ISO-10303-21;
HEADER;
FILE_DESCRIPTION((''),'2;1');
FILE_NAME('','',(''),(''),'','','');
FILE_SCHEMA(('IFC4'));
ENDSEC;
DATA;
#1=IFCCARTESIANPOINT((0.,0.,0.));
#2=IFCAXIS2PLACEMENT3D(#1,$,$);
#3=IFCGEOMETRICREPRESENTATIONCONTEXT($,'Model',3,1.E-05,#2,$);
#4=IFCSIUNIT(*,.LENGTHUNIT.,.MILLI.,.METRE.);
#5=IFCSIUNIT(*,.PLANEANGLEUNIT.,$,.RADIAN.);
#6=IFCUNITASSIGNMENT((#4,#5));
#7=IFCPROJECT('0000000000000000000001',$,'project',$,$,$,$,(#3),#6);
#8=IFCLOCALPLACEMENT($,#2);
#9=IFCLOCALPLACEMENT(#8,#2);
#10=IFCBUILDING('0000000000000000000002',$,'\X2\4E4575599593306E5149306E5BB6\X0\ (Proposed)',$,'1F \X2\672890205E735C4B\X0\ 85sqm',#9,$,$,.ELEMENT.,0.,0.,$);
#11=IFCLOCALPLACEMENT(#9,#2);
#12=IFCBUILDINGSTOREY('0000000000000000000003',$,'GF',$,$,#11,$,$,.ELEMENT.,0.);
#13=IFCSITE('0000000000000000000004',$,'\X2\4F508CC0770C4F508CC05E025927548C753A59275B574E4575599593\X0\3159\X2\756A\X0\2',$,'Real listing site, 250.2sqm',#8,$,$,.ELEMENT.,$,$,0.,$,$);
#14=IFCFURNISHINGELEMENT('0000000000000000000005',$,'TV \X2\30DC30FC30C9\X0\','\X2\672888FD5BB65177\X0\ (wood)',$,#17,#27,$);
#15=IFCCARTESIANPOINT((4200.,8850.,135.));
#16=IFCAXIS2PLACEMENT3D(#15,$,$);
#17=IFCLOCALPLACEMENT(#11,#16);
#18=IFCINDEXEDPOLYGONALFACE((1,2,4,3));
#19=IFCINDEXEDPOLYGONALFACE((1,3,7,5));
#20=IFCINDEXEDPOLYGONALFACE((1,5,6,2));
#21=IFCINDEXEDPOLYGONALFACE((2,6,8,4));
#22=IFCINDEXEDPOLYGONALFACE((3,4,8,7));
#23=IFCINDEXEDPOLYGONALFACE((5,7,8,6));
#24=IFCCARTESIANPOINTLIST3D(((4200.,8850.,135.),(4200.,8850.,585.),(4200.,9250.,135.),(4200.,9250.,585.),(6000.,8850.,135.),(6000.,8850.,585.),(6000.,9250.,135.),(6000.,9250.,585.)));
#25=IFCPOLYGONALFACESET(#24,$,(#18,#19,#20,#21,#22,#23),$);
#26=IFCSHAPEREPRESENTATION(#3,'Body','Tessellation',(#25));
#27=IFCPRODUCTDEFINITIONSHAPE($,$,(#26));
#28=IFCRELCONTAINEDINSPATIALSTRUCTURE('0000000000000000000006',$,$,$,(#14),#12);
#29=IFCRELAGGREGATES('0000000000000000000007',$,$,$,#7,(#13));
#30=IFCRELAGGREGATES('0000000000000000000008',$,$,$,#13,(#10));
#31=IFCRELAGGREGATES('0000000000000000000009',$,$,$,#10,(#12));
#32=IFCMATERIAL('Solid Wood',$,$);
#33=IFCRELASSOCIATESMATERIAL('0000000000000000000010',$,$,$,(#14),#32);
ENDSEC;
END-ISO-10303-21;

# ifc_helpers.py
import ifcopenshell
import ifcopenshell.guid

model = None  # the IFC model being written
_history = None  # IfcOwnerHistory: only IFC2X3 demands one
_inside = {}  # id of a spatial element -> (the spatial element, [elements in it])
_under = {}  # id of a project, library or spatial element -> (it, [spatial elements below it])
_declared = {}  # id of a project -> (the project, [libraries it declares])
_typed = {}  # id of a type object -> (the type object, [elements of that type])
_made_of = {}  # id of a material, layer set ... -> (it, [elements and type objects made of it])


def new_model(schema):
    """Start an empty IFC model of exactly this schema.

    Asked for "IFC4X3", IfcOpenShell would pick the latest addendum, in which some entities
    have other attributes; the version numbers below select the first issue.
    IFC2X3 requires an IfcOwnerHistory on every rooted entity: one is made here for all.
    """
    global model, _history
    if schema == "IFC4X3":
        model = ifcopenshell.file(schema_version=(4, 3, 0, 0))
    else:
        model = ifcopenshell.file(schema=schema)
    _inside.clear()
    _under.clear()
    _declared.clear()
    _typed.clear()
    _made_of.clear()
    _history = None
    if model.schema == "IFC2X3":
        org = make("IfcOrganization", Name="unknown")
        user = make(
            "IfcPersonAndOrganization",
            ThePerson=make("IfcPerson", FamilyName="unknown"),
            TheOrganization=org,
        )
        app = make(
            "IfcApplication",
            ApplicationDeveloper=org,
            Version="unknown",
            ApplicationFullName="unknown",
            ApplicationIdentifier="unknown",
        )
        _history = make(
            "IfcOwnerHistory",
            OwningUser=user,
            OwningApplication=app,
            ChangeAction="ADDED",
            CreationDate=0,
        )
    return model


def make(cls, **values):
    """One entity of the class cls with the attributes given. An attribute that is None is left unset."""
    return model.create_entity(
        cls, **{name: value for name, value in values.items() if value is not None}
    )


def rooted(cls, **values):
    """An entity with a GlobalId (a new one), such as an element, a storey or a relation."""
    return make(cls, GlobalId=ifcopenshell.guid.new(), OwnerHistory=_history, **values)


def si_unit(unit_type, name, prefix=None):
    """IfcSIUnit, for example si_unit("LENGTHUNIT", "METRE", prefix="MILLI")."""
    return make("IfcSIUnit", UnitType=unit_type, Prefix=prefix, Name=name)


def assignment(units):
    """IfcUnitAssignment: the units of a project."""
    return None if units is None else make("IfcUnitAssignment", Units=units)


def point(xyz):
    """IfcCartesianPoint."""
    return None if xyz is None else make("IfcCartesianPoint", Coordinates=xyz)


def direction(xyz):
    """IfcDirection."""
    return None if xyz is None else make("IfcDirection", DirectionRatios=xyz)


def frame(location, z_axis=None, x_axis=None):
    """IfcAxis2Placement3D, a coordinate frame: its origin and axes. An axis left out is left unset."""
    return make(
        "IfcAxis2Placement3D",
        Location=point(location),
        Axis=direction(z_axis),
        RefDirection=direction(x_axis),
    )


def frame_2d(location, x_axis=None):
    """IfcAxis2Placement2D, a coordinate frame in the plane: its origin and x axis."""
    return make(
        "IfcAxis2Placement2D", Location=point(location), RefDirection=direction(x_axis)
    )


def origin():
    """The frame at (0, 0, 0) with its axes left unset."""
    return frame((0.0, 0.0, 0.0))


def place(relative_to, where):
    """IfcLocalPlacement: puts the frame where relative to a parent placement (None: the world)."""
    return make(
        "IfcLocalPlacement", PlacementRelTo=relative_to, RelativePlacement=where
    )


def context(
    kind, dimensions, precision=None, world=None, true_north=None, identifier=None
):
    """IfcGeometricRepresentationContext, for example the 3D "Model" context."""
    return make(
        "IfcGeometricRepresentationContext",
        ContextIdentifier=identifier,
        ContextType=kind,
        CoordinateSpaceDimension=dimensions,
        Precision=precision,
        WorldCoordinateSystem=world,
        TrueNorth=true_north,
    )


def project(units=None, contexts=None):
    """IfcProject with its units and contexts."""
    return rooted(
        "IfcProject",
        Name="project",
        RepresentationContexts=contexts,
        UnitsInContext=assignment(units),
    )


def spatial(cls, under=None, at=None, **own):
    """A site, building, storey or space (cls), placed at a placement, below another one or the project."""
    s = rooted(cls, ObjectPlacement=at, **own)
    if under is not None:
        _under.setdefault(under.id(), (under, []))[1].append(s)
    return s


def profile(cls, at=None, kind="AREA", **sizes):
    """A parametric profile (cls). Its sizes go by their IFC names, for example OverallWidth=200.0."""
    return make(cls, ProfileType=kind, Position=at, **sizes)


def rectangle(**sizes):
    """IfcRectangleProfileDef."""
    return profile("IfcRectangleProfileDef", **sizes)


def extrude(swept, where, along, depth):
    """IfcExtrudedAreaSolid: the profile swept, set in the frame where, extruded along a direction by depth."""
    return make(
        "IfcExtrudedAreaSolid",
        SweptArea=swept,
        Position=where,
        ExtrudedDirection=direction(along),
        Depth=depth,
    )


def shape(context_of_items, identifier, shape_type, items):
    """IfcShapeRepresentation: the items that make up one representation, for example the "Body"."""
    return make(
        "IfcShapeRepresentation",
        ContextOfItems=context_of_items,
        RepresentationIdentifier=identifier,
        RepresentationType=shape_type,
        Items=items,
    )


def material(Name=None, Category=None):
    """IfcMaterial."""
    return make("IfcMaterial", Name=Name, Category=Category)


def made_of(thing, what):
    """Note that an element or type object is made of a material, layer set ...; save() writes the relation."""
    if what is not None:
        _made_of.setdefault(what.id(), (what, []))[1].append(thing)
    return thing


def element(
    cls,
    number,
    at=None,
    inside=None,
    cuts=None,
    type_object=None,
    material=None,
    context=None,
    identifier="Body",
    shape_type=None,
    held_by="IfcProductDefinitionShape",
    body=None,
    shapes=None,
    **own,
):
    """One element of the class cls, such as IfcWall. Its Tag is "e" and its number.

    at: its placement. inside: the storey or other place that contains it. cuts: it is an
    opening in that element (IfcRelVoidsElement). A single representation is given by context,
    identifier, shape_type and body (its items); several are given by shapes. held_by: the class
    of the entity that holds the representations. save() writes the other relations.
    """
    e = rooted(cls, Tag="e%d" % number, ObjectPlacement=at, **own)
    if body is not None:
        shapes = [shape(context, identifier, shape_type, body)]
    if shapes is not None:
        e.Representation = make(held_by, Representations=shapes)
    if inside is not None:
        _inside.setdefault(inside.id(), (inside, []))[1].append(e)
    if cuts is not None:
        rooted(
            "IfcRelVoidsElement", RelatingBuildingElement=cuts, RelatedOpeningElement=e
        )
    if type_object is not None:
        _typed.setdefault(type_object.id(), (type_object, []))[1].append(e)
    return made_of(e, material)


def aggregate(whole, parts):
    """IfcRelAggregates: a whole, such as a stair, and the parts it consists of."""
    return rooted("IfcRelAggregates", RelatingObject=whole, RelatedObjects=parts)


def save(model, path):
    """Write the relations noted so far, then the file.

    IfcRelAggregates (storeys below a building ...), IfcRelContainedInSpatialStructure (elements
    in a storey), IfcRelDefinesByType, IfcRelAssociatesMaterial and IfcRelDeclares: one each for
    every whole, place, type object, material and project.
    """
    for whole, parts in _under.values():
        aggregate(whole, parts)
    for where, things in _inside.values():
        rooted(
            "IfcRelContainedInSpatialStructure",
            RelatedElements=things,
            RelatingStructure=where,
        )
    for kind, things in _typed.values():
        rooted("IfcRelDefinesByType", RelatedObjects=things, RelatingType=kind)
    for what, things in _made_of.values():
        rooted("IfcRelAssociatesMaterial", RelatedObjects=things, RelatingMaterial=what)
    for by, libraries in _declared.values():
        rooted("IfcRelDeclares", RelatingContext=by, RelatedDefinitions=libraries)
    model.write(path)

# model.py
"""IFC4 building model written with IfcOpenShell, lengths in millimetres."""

from ifc_helpers import new_model, si_unit, frame, frame_2d, origin, place, context, project, spatial, rectangle, extrude, material, element, save


model = new_model("IFC4")

# Units and contexts
model_context = context("Model", 3, precision=1e-05, world=origin())
ifc_project = project(units=[si_unit("LENGTHUNIT", "METRE", prefix="MILLI"), si_unit("PLANEANGLEUNIT", "RADIAN")], contexts=[model_context])

# Site, building, storey
site_placement = place(None, origin())
site = spatial("IfcSite", under=ifc_project, at=site_placement, Name="佐賀県佐賀市大和町大字久留間3159番2", ObjectType="Real listing site, 250.2sqm", CompositionType="ELEMENT", RefElevation=0.0)
building_placement = place(site_placement, origin())
building = spatial("IfcBuilding", under=site, at=building_placement, Name="久留間の光の家 (Proposed)", ObjectType="1F 木造平屋 85sqm", CompositionType="ELEMENT", ElevationOfRefHeight=0.0, ElevationOfTerrain=0.0)
storey_placement = place(building_placement, origin())
storey = spatial("IfcBuildingStorey", under=building, at=storey_placement, Name="GF", CompositionType="ELEMENT", Elevation=0.0)

# Shared definitions
ifc_material_1 = material(Name="Solid Wood")

# Furnishing element
furnishing_placement = place(storey_placement, frame((4200.0, 8850.0, 135.0)))
element("IfcFurnishingElement", 1, at=furnishing_placement, inside=storey, material=ifc_material_1, Name="TV ボード", Description="木製家具 (wood)", context=model_context, shape_type="SweptSolid", body=[
    extrude(rectangle(XDim=1800.0, YDim=400.0, at=frame_2d((900.0, 200.0))), frame((4200.0, 8850.0, 135.0)), (0.0, 0.0, 1.0), 450.0),
])

save(model, "model.ifc")
